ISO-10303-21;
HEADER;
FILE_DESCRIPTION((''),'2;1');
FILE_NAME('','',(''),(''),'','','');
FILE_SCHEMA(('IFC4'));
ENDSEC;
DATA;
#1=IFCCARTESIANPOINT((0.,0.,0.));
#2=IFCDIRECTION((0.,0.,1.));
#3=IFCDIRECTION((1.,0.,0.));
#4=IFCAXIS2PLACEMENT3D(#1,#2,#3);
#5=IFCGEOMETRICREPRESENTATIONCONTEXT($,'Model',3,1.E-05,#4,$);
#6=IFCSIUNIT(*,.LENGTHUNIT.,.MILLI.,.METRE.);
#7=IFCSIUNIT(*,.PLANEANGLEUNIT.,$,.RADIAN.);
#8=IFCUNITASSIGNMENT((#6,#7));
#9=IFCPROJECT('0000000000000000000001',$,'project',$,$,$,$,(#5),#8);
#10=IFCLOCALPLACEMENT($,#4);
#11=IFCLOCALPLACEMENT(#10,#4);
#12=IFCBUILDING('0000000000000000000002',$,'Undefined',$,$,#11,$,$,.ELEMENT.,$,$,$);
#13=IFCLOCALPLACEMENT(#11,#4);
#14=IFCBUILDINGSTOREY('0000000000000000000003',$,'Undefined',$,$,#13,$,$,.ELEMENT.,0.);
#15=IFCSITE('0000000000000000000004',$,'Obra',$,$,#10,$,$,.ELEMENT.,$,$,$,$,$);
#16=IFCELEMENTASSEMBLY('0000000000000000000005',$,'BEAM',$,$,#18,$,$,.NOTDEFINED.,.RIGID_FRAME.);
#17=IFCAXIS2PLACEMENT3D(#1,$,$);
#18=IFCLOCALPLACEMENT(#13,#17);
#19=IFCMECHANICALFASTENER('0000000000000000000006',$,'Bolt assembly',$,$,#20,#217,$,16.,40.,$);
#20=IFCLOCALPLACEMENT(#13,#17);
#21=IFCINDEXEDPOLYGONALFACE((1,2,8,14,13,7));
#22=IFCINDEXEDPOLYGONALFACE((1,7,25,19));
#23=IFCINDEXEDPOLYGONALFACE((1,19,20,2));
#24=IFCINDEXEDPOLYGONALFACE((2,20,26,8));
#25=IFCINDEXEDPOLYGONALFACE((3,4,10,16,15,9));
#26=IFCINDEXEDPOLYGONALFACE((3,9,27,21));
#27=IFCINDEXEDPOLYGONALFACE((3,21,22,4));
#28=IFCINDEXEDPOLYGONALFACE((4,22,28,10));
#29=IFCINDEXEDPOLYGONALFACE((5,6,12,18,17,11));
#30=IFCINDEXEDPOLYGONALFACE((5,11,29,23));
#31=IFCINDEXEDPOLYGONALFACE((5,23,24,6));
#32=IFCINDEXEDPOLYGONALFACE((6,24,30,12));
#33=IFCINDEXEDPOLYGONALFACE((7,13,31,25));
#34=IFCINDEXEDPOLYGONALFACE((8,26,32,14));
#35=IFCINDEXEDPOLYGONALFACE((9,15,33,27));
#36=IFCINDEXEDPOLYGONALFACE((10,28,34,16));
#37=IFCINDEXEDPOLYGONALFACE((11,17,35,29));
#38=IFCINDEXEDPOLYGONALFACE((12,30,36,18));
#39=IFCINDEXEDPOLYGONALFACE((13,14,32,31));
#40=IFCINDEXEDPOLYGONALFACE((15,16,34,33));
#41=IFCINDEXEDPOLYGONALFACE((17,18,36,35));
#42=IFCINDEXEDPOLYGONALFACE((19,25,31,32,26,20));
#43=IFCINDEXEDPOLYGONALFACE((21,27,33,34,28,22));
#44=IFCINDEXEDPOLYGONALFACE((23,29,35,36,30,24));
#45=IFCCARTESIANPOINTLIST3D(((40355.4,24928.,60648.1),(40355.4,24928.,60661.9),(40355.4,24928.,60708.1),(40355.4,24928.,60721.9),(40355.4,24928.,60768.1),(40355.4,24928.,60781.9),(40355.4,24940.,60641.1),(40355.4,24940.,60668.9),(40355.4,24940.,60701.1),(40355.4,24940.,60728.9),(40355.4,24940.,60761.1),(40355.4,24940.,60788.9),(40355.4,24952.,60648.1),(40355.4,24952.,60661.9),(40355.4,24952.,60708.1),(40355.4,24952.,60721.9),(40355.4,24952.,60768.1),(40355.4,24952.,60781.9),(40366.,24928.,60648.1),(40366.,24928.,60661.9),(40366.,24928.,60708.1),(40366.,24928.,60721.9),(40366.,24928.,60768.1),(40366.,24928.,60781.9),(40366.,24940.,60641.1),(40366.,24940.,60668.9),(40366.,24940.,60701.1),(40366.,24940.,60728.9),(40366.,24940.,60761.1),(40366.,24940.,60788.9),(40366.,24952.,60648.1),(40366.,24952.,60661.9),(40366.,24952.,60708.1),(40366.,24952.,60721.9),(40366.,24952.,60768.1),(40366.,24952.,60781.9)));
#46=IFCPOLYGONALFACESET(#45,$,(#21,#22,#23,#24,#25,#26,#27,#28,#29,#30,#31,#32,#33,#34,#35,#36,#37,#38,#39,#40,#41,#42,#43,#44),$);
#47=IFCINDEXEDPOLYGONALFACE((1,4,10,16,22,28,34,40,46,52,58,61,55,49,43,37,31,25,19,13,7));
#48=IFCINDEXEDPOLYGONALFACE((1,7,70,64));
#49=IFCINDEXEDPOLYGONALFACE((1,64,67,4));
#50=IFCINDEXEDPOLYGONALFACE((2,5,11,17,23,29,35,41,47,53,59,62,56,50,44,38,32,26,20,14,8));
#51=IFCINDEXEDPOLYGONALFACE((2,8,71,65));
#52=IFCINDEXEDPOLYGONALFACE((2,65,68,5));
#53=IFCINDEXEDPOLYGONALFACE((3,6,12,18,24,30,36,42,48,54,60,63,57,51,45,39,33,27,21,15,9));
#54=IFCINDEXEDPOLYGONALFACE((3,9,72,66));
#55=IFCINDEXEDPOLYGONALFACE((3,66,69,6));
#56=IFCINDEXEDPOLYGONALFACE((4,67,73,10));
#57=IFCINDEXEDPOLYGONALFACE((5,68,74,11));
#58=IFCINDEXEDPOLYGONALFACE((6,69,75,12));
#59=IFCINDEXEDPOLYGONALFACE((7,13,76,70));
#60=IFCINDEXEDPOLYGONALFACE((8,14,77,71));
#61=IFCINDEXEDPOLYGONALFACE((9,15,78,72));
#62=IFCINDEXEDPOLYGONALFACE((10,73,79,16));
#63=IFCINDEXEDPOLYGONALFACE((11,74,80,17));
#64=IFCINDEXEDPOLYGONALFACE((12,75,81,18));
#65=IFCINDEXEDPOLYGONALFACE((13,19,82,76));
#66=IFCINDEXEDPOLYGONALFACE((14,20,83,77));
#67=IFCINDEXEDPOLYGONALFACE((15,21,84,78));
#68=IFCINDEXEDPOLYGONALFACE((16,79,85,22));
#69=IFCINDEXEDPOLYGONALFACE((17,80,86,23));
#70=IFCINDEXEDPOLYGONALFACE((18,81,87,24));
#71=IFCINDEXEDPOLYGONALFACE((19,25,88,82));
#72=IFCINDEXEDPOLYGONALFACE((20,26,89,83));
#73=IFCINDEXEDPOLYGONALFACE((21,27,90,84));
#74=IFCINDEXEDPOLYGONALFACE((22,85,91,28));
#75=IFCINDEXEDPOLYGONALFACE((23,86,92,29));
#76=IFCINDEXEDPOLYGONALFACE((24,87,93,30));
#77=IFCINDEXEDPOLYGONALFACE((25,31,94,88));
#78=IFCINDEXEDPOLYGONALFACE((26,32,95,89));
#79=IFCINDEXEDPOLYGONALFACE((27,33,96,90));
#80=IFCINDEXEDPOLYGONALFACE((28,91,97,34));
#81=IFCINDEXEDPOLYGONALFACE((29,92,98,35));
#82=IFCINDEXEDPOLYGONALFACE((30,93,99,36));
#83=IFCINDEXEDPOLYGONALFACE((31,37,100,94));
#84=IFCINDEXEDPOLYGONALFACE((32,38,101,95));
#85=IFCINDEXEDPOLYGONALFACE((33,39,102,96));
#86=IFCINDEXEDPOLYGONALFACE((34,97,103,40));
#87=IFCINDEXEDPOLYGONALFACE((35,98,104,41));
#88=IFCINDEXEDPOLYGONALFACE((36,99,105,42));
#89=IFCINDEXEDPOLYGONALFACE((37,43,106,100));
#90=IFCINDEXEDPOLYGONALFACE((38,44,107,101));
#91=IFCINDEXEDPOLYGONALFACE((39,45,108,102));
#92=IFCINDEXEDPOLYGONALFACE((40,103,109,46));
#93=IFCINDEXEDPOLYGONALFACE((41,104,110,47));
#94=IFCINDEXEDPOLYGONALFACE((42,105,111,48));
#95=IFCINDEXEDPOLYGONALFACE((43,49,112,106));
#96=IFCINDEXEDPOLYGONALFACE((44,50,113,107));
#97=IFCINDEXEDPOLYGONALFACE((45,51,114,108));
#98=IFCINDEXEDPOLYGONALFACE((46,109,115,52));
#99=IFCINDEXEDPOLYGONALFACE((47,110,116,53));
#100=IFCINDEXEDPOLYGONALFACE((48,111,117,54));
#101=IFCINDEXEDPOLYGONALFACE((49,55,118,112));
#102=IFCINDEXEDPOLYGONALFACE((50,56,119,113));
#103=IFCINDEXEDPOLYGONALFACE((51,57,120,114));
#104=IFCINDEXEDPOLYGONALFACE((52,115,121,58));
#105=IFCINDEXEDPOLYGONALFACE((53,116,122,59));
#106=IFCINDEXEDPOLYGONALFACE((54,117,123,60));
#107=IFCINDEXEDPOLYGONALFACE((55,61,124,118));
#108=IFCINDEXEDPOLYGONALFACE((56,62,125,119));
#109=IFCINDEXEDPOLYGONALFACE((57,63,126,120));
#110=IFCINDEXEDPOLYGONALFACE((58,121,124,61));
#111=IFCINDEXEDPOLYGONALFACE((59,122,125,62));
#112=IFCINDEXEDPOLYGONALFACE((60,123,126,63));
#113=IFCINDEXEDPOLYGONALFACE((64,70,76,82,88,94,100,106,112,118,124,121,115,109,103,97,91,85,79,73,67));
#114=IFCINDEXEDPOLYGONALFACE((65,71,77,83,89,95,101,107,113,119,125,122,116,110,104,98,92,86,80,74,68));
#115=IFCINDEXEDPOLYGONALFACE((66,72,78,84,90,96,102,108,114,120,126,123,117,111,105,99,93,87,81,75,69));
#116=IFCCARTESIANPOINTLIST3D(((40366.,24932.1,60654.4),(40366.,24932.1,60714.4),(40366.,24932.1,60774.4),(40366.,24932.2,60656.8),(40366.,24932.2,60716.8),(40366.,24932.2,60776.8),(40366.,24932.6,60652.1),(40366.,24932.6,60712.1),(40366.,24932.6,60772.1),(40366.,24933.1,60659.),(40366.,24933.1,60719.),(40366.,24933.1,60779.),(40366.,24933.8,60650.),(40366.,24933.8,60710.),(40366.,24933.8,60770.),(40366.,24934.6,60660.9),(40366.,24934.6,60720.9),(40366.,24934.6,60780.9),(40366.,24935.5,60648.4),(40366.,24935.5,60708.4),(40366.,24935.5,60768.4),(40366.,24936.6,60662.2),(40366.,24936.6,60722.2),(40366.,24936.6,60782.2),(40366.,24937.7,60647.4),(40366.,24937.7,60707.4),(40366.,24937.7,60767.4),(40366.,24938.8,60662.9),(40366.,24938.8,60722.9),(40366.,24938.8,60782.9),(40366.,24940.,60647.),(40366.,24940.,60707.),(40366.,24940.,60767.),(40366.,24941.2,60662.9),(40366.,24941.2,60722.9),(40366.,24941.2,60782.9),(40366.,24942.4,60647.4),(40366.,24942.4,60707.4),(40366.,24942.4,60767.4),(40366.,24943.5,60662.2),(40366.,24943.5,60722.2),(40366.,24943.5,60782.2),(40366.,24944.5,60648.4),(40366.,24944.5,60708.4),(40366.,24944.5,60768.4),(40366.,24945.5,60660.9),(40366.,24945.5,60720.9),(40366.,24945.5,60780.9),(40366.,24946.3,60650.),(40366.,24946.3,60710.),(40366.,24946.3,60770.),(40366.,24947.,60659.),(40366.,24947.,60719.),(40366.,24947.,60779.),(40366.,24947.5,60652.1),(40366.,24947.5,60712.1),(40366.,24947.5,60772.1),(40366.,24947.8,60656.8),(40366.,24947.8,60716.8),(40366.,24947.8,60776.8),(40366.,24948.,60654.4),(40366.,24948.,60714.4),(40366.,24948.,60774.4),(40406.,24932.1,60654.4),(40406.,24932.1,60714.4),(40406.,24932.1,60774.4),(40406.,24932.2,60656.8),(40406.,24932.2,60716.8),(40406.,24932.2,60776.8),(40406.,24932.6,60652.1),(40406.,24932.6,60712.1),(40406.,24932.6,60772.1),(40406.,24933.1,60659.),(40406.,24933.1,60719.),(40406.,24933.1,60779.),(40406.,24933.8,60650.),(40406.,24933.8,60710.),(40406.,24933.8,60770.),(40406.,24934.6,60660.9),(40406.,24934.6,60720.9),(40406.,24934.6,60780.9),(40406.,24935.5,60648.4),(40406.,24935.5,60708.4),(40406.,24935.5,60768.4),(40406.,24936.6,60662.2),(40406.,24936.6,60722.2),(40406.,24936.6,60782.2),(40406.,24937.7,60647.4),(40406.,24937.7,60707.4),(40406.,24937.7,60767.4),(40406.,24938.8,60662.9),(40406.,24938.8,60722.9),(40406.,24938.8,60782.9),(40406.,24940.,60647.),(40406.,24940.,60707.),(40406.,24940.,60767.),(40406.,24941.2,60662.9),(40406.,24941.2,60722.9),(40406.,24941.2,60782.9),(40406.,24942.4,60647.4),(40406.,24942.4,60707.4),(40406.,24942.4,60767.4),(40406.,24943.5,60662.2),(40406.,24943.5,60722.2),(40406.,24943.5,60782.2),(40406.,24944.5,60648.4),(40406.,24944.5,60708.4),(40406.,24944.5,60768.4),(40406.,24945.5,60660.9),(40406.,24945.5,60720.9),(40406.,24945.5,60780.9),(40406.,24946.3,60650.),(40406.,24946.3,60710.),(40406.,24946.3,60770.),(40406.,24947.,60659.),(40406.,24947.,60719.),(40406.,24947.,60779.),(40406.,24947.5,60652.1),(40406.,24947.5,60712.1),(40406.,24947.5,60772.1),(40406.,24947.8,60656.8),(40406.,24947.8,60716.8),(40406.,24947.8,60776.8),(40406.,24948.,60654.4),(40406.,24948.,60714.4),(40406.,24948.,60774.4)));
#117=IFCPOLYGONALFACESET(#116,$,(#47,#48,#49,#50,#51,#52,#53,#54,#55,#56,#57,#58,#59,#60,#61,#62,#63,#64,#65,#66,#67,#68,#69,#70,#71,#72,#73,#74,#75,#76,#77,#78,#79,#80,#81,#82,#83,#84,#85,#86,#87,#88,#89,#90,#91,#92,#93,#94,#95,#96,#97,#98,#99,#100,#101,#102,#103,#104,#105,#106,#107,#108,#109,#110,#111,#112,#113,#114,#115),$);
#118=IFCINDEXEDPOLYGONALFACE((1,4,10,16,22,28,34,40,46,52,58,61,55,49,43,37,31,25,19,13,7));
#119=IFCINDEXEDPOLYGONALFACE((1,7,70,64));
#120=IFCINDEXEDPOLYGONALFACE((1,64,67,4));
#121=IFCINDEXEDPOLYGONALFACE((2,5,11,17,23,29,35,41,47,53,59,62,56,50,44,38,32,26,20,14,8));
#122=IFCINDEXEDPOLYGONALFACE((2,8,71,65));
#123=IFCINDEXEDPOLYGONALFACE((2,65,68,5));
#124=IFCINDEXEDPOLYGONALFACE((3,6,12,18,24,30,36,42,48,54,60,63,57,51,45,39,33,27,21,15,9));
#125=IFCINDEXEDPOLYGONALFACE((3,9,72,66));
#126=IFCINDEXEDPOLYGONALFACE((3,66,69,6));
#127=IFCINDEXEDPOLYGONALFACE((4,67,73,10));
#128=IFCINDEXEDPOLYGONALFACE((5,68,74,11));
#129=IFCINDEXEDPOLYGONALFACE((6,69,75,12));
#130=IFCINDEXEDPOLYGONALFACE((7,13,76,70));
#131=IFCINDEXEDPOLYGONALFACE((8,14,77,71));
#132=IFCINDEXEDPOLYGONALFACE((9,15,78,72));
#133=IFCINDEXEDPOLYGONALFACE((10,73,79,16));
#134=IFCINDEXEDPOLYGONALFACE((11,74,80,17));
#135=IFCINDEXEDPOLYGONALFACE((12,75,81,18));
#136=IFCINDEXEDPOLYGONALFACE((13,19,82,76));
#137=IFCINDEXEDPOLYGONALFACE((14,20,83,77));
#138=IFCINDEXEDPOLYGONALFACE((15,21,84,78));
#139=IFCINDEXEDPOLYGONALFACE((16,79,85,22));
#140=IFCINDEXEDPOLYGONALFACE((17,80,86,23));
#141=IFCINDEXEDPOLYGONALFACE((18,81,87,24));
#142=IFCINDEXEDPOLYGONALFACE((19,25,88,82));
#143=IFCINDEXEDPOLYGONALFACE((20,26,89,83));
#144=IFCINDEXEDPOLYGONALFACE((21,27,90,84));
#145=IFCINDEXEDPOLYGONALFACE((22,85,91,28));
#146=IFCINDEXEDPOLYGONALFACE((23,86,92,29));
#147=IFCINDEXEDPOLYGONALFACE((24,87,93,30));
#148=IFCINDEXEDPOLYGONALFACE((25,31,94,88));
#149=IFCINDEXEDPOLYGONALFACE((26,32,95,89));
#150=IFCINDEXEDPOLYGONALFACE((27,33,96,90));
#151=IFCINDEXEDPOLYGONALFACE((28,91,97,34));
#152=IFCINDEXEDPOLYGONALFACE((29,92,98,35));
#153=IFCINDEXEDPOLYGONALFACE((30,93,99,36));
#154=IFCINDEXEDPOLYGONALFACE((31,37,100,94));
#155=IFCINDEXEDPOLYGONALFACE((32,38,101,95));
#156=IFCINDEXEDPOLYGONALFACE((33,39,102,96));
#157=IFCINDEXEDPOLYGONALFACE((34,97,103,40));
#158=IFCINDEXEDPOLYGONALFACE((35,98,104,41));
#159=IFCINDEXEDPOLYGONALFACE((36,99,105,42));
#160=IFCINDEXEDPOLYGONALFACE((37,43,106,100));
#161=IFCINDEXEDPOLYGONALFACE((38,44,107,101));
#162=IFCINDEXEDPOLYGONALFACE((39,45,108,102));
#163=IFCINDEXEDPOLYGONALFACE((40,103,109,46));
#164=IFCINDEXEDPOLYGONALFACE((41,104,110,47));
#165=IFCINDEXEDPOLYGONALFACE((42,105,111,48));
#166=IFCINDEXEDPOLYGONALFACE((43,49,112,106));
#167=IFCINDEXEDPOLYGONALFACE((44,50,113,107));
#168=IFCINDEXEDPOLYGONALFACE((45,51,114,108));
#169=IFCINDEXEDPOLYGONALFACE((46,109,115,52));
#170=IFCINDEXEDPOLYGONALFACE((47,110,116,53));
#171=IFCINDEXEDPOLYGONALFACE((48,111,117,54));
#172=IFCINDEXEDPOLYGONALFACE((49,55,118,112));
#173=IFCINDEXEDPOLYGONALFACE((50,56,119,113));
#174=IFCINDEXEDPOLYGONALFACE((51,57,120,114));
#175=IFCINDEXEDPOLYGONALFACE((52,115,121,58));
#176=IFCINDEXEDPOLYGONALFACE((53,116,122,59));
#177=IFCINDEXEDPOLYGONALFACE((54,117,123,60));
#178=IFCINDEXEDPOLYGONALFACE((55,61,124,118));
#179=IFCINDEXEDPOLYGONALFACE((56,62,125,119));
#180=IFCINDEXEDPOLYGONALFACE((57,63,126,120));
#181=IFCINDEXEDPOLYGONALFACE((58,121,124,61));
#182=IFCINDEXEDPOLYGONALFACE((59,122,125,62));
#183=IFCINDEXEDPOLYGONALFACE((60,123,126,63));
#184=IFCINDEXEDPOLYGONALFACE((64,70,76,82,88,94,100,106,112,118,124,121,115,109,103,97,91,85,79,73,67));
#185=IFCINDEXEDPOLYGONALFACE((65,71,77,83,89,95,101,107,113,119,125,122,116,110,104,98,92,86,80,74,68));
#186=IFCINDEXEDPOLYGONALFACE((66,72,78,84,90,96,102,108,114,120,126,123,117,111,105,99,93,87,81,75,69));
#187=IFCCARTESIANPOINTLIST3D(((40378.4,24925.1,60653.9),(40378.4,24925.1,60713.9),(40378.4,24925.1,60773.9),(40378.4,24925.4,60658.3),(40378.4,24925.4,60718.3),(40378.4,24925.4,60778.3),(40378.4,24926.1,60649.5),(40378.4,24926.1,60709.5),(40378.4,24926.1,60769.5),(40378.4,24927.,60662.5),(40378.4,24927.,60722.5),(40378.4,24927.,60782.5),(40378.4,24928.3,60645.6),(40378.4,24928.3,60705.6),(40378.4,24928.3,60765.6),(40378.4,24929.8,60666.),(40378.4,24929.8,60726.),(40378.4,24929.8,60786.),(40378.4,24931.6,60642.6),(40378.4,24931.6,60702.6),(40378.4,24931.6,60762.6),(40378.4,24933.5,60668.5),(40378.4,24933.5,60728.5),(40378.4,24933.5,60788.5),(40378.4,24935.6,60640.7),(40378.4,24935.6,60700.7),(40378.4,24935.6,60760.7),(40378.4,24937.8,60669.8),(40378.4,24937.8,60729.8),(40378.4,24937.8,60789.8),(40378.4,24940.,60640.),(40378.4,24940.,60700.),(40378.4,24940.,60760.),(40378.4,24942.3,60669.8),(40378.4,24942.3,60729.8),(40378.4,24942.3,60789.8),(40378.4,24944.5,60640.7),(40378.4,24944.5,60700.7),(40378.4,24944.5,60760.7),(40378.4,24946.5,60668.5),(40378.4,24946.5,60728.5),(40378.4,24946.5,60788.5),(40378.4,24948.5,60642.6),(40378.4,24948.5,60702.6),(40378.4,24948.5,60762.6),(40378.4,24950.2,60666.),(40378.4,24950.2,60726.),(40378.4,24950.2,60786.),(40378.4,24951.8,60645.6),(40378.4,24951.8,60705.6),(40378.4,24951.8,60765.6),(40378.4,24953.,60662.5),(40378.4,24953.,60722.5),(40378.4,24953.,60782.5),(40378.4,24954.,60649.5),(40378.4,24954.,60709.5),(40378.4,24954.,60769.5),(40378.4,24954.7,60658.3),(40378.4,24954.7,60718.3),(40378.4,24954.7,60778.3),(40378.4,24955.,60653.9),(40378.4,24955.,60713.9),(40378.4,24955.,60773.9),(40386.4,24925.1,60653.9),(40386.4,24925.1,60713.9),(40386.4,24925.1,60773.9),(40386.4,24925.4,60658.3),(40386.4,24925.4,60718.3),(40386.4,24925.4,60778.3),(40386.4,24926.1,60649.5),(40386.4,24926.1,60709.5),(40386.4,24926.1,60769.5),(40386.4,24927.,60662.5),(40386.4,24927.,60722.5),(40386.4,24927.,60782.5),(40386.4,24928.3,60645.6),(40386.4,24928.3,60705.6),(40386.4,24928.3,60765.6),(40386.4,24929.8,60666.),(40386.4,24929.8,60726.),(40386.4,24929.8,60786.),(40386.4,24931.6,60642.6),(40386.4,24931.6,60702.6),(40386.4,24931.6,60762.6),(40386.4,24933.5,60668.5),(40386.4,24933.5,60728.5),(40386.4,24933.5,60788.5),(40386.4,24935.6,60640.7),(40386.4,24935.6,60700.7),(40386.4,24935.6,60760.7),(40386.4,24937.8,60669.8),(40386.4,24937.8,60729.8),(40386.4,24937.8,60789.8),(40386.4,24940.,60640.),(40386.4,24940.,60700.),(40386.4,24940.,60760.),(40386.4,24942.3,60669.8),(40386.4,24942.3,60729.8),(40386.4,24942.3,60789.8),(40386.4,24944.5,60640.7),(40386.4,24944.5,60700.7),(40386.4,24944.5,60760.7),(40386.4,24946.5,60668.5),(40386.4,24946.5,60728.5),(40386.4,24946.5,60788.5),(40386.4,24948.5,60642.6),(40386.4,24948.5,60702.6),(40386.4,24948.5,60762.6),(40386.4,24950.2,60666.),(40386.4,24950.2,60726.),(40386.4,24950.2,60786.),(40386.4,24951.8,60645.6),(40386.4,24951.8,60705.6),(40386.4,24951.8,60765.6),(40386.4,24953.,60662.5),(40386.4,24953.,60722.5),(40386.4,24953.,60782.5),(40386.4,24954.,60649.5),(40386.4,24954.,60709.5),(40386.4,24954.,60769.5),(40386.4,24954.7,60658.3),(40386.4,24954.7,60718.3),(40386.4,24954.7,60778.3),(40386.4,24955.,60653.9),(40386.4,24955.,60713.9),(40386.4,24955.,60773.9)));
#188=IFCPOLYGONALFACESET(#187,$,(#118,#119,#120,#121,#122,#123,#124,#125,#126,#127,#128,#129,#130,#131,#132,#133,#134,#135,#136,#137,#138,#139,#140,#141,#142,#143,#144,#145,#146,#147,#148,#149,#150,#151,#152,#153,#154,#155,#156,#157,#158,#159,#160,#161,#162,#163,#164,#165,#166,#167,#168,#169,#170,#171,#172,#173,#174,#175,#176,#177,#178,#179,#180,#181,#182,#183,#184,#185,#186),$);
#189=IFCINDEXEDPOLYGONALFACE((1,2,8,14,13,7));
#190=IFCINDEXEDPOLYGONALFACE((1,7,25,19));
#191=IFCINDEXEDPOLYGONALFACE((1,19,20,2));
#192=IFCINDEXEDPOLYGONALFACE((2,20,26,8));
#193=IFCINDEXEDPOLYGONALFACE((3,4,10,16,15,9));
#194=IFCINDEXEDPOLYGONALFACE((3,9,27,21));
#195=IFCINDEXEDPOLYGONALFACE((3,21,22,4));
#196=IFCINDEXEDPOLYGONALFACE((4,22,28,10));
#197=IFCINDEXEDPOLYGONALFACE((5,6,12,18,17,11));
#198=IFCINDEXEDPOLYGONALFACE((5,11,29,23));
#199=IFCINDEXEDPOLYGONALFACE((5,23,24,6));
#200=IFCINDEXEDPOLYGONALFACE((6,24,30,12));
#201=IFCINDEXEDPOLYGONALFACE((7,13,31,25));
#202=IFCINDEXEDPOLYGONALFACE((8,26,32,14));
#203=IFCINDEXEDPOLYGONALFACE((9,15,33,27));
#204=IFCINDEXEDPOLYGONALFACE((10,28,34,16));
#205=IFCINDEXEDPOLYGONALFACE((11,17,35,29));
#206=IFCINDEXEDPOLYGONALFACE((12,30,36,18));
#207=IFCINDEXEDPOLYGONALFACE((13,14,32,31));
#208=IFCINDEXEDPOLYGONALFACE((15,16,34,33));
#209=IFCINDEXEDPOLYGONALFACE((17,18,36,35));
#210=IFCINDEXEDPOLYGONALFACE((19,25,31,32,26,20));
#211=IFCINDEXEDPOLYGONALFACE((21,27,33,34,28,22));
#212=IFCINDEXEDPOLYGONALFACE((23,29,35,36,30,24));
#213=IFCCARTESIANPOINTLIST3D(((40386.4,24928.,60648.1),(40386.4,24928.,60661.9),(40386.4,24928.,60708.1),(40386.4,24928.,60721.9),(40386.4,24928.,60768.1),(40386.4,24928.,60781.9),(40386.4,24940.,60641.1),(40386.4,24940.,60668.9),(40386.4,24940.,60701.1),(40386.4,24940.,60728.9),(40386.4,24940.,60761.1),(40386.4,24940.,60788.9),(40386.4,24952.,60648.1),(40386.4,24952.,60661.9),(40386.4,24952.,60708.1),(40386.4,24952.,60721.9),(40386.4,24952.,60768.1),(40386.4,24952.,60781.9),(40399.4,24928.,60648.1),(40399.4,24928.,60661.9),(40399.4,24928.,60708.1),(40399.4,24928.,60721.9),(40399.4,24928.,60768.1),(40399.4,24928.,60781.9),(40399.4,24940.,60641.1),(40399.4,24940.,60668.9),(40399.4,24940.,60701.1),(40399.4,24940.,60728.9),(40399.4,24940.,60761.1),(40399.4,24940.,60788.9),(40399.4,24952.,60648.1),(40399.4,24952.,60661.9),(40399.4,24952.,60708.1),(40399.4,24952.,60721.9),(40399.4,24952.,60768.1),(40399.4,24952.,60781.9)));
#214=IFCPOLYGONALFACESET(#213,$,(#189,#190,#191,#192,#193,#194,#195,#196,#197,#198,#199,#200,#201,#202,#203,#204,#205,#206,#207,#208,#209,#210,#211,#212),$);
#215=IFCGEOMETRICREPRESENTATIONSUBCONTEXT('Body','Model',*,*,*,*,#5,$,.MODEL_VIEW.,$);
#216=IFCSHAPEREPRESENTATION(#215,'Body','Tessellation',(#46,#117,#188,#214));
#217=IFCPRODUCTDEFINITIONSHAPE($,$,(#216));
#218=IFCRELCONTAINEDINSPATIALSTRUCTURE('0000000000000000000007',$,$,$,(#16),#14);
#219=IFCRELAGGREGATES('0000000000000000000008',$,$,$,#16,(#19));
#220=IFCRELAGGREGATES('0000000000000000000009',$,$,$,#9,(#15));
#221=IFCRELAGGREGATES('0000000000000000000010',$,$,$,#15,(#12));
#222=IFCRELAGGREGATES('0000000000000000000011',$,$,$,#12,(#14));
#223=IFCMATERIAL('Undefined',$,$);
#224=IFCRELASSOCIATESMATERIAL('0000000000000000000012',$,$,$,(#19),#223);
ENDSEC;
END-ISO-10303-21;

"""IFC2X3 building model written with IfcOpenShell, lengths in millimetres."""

from ifc_helpers import new_model, si_unit, frame, origin_with_axes, origin_2d_with_axis, place, context, subcontext, project, spatial, polyline, circle, outline, extrude, source, transform, mapped, material, element, aggregate, save


model = new_model("IFC2X3")

# Units and contexts
model_context = context("Model", 3, precision=1e-05, world=origin_with_axes())
body_context = subcontext(model_context, "Body", "Model", "MODEL_VIEW")
ifc_project = project(units=[si_unit("LENGTHUNIT", "METRE", prefix="MILLI"), si_unit("PLANEANGLEUNIT", "RADIAN")], contexts=[model_context])

# Site, building, storey
site_placement = place(None, origin_with_axes())
site = spatial("IfcSite", under=ifc_project, at=site_placement, Name="Obra", CompositionType="ELEMENT")
building_placement = place(site_placement, origin_with_axes())
building = spatial("IfcBuilding", under=site, at=building_placement, Name="Undefined", CompositionType="ELEMENT")
storey_placement = place(building_placement, origin_with_axes())
storey = spatial("IfcBuildingStorey", under=building, at=storey_placement, Name="Undefined", CompositionType="ELEMENT", Elevation=0.0)

# Element assembly
ifc_material_1 = material(Name="Undefined")
assembly_1_placement = place(storey_placement, origin_with_axes())
assembly_1 = element("IfcElementAssembly", 1, at=assembly_1_placement, inside=storey, Name="BEAM", AssemblyPlace="NOTDEFINED", PredefinedType="RIGID_FRAME")

# Mechanical fastener
shared_shape_1 = source(origin_with_axes(), body_context, "Body", "SweptSolid", [
    extrude(outline(polyline([(13.9, 0.0), (6.9, 12.0), (-6.9, 12.0), (-13.9, 0.0), (-6.9, -12.0), (6.9, -12.0), (13.9, 0.0)])), frame((0.0, -19.7, 0.0), z_axis=(0.0, 1.0, 0.0), x_axis=(1.0, 0.0, 0.0)), (0.0, 0.0, 1.0), 10.6),
    extrude(circle(Radius=8.0, at=origin_2d_with_axis()), frame((0.0, -9.1, 0.0), z_axis=(0.0, 1.0, 0.0), x_axis=(1.0, 0.0, 0.0)), (0.0, 0.0, 1.0), 40.0),
    extrude(circle(Radius=15.0, at=origin_2d_with_axis()), frame((0.0, 3.3, 0.0), z_axis=(0.0, 1.0, 0.0), x_axis=(1.0, 0.0, 0.0)), (0.0, 0.0, 1.0), 8.0),
    extrude(outline(polyline([(13.9, 0.0), (6.9, 12.0), (-6.9, 12.0), (-13.9, 0.0), (-6.9, -12.0), (6.9, -12.0), (13.9, 0.0)])), frame((0.0, 11.3, 0.0), z_axis=(0.0, 1.0, 0.0), x_axis=(1.0, 0.0, 0.0)), (0.0, 0.0, 1.0), 13.0),
])
mechanical_fastener_1_placement = place(assembly_1_placement, frame((40375.1, 24990.0, 60835.0), z_axis=(0.000002, -1.0, 0.0), x_axis=(0.0, 0.0, -1.0)))
mechanical_fastener_1 = element("IfcMechanicalFastener", 2, at=mechanical_fastener_1_placement, material=ifc_material_1, Name="Bolt assembly", NominalDiameter=16.0, NominalLength=40.0, context=body_context, shape_type="MappedRepresentation", body=[
    mapped(shared_shape_1, transform((60.0, 0.0, 50.0))),
    mapped(shared_shape_1, transform((120.0, 0.0, 50.0))),
    mapped(shared_shape_1, transform((180.0, 0.0, 50.0))),
])
aggregate(assembly_1, [mechanical_fastener_1])

save(model, "model.ifc")
